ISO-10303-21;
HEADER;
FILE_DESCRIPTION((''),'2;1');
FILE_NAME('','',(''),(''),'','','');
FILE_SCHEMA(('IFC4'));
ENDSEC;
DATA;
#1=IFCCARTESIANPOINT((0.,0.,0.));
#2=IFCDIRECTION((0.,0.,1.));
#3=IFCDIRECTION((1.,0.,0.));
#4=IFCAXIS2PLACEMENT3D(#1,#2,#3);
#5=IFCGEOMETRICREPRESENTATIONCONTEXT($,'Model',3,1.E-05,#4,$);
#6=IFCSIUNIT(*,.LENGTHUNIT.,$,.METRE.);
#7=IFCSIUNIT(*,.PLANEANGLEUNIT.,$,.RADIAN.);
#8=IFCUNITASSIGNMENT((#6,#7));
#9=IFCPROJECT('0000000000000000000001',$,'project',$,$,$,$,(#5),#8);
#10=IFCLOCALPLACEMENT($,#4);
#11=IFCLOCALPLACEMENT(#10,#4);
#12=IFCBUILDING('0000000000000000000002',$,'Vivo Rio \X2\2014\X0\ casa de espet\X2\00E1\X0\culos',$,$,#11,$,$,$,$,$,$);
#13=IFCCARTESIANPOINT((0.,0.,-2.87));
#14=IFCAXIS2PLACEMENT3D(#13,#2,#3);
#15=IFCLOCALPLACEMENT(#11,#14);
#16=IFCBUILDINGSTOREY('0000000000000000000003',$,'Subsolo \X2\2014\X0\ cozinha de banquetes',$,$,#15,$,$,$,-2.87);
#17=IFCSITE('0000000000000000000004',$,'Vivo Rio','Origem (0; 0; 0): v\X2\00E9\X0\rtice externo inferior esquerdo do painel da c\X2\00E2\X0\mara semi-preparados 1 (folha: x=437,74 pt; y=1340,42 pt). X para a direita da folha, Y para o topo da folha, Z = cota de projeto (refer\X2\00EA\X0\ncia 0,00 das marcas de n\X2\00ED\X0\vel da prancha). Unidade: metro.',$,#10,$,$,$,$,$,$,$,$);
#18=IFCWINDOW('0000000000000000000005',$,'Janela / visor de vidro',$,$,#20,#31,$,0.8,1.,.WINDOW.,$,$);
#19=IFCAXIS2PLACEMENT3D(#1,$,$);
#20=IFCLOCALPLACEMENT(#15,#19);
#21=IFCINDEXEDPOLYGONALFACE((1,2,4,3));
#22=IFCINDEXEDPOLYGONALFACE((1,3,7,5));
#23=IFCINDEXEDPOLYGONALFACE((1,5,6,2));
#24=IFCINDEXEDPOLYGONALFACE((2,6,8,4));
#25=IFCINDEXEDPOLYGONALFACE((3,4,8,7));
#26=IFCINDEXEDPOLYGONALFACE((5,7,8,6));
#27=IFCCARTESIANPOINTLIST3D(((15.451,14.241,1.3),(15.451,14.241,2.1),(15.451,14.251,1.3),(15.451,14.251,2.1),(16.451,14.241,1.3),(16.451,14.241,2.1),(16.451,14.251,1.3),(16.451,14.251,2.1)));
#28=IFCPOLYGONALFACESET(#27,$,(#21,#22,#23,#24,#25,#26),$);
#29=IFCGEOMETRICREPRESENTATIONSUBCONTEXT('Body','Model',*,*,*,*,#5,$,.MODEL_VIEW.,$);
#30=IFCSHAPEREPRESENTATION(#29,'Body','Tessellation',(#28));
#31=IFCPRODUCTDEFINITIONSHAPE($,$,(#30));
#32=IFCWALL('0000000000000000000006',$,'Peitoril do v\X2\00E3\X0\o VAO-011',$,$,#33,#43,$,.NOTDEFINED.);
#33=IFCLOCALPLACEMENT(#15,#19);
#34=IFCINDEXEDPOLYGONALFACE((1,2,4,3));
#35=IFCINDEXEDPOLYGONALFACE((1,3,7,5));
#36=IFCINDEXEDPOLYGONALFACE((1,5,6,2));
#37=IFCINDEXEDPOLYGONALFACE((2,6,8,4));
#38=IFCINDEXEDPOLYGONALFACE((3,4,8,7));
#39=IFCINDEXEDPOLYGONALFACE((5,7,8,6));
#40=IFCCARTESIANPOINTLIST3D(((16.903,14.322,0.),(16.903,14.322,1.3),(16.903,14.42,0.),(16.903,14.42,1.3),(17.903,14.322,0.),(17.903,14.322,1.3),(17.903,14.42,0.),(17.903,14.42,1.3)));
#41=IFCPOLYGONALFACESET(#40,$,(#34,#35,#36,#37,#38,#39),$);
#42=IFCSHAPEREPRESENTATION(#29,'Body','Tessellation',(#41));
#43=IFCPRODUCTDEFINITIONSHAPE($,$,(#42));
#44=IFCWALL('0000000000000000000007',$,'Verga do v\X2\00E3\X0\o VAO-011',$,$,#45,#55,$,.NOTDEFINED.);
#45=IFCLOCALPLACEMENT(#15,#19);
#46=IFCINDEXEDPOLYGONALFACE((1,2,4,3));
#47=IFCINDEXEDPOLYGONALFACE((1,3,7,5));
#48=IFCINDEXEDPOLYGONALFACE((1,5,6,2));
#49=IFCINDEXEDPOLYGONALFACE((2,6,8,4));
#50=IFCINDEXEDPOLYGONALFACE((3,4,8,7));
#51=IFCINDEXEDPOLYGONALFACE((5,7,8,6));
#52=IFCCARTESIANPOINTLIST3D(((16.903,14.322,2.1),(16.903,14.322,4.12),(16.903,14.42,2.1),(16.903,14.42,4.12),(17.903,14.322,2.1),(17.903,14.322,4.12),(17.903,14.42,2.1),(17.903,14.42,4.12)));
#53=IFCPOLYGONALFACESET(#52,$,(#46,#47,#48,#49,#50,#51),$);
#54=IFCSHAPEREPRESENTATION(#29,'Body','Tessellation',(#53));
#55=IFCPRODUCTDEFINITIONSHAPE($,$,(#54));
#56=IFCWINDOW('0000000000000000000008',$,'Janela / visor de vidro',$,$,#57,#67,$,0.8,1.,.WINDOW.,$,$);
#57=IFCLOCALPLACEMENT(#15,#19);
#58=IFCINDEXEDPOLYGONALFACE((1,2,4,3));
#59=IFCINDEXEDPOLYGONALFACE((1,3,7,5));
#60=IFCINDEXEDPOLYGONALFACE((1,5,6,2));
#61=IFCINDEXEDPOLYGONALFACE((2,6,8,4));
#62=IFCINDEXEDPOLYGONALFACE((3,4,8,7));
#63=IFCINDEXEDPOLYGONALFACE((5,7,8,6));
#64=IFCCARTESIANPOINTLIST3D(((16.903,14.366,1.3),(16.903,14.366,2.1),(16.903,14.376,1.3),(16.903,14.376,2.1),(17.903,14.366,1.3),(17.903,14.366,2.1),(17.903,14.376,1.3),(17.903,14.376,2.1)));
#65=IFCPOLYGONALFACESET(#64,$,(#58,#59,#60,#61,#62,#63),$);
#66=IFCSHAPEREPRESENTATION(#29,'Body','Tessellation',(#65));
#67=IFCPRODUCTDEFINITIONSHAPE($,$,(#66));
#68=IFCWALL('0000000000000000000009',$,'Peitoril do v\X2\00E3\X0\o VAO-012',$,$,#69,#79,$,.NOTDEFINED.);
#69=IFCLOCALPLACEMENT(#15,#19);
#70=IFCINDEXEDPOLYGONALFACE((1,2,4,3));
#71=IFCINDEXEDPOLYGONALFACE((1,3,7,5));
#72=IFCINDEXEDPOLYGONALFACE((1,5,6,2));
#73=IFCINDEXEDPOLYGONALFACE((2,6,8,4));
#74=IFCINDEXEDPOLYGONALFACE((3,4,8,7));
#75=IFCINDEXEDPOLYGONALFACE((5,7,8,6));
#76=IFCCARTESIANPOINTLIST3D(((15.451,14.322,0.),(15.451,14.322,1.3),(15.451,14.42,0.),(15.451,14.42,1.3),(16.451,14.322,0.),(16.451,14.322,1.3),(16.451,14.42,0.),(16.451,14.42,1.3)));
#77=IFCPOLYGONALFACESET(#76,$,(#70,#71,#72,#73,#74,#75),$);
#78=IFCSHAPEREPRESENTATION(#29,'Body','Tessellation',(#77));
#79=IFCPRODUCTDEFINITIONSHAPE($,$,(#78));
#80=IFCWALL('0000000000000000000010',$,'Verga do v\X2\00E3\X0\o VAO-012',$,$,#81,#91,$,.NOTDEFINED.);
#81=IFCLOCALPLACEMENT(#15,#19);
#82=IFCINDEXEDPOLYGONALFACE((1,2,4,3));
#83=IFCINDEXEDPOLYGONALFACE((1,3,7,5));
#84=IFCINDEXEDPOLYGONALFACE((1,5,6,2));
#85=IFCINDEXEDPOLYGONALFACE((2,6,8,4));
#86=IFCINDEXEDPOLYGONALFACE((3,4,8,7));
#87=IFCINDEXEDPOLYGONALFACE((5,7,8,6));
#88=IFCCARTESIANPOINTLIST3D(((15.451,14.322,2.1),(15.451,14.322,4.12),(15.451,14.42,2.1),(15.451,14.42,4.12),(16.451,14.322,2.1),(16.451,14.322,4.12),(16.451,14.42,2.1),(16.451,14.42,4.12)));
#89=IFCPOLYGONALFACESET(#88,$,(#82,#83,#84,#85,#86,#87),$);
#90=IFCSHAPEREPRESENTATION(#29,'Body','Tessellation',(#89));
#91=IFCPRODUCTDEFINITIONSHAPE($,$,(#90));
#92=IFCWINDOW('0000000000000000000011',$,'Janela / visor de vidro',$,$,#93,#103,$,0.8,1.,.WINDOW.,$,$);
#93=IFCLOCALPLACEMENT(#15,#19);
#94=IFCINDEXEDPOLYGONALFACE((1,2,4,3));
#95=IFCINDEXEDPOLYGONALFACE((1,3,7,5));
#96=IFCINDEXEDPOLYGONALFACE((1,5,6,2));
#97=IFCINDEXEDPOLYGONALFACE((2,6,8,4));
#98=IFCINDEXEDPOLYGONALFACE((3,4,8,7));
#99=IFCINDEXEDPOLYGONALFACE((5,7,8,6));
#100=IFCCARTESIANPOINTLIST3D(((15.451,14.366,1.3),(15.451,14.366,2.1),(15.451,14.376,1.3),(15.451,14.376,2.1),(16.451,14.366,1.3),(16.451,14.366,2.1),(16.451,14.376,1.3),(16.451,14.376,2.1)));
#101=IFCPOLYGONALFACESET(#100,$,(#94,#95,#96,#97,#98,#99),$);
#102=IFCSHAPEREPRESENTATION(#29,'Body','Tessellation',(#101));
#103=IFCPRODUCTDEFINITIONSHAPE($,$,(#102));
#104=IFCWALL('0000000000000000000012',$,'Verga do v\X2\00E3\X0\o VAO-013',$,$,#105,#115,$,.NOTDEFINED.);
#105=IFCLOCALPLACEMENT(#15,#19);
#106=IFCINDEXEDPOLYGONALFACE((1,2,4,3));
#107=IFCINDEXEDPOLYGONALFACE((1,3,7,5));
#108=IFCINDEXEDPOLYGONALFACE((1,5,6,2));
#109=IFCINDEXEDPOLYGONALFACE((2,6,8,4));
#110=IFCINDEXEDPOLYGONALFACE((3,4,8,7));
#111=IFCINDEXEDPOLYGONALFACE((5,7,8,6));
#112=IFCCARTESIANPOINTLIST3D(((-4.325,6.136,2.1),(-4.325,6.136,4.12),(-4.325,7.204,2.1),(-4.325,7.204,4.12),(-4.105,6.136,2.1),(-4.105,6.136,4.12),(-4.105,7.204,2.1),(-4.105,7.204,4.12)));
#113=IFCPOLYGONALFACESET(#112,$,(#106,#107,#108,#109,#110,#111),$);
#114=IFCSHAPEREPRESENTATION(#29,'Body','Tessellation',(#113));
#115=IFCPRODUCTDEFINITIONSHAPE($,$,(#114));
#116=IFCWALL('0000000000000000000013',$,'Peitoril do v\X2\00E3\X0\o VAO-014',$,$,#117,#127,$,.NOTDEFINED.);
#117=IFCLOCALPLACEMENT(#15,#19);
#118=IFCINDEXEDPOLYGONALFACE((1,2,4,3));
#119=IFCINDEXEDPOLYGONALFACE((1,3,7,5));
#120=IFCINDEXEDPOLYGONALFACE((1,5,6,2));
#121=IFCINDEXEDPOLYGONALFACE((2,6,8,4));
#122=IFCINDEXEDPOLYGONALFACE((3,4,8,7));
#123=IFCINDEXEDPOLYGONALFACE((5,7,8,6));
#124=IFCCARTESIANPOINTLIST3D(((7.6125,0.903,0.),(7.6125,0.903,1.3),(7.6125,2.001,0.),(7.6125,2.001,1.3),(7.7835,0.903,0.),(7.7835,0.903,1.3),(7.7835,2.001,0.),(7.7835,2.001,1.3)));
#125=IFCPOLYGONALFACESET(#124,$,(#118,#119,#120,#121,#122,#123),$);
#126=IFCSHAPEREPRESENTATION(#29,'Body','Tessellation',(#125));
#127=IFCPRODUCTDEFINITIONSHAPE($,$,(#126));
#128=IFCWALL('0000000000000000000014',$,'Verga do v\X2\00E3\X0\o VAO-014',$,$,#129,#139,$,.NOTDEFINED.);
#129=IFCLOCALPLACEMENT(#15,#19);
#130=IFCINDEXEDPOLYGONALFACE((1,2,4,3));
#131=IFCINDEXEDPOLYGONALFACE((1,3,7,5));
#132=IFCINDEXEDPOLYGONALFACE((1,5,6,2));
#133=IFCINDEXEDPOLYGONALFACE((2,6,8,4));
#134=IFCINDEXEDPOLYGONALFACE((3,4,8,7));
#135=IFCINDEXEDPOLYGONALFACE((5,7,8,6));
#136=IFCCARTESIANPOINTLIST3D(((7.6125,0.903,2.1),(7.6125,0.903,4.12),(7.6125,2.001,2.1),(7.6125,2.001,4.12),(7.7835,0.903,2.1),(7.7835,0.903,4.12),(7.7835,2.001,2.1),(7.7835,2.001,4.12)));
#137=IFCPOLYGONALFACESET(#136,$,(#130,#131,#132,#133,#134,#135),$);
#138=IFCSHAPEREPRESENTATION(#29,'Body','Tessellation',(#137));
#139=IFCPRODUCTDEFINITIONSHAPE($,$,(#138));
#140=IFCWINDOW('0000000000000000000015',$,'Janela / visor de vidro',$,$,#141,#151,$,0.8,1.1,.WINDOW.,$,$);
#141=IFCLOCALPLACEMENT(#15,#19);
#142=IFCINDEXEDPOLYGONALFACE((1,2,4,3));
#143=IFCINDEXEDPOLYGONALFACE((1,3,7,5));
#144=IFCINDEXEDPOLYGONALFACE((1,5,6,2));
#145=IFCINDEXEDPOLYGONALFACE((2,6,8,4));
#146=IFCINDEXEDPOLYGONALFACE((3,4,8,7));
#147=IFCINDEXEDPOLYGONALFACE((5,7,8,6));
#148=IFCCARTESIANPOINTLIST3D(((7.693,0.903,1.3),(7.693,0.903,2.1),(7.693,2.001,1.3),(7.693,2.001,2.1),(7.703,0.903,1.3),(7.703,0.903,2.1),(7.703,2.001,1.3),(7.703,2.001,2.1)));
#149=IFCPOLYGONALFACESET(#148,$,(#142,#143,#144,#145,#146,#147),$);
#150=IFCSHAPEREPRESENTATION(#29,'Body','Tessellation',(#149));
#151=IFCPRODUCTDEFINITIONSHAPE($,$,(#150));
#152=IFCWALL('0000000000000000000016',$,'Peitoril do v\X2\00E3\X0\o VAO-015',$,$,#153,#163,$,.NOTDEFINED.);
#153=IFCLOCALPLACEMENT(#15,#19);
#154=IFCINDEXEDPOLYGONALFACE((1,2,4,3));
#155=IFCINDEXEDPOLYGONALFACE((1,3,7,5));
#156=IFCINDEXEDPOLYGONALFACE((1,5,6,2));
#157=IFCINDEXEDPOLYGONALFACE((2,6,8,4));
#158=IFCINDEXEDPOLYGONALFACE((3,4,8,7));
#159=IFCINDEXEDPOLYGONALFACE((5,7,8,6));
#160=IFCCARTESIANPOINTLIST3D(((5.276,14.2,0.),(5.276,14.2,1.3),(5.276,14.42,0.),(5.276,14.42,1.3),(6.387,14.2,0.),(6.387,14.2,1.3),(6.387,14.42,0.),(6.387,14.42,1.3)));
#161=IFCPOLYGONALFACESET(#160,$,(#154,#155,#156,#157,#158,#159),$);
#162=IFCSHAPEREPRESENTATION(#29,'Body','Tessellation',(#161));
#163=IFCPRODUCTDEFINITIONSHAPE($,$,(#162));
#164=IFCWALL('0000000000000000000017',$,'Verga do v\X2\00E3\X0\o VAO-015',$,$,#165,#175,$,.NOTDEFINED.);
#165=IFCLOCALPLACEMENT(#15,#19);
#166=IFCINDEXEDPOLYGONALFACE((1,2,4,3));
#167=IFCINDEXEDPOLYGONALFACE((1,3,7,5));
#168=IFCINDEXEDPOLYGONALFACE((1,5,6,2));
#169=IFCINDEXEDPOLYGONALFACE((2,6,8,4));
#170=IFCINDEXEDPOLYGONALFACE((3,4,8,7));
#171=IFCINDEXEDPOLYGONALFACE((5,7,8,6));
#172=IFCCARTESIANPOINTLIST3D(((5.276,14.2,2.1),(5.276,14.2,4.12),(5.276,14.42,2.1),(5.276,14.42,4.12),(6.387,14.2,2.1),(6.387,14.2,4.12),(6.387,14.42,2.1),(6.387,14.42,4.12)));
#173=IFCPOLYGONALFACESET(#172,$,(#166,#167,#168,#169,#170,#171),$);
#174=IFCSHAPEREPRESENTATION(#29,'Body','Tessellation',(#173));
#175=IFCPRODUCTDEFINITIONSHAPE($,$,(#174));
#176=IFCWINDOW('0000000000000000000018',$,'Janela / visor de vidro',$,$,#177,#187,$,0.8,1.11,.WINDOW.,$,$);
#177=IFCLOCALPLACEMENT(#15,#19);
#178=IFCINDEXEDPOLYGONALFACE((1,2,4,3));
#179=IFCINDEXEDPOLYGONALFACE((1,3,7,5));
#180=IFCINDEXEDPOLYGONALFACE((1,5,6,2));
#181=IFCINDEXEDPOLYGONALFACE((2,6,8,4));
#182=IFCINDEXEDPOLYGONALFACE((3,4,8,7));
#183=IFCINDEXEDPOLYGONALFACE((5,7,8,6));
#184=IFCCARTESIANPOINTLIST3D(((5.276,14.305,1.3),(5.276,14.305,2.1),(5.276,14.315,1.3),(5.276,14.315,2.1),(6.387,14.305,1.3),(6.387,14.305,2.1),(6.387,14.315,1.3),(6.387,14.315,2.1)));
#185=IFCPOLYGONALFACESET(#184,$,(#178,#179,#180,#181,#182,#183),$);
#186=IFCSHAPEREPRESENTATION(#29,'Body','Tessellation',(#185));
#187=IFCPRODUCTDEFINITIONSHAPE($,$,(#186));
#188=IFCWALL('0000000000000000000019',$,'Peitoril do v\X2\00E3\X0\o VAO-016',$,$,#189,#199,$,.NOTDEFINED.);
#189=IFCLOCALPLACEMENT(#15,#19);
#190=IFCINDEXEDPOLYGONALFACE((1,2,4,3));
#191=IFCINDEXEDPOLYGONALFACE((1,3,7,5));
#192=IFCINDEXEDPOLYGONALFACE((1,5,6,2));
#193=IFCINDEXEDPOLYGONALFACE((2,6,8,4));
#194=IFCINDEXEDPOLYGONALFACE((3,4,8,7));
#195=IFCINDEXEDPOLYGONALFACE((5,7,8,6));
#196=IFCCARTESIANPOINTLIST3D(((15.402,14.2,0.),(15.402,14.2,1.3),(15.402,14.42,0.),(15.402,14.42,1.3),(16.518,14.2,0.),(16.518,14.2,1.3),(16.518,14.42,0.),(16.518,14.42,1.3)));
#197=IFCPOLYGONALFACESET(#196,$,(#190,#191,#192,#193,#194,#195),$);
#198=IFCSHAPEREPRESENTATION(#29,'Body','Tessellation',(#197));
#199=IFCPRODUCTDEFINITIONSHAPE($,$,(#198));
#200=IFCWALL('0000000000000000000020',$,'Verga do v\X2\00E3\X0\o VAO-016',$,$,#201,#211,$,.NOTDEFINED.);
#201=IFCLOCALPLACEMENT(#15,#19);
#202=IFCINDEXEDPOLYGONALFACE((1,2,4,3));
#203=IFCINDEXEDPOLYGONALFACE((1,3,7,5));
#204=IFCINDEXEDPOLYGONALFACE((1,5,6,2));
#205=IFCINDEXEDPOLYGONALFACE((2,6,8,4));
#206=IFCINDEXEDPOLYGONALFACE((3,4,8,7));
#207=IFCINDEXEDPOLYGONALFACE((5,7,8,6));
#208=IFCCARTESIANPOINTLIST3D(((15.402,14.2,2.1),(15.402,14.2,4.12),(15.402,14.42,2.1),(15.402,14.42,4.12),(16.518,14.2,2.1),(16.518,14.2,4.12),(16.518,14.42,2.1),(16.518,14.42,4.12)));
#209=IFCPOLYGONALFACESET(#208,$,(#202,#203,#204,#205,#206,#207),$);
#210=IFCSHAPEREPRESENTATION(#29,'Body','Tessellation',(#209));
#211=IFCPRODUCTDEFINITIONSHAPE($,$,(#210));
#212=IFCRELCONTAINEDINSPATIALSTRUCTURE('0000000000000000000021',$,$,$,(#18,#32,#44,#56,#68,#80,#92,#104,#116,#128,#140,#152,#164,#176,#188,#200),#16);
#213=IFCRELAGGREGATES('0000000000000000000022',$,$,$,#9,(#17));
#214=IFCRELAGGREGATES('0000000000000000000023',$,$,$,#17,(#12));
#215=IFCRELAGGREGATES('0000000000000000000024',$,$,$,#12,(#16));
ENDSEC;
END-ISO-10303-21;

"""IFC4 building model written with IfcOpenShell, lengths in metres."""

from ifc_helpers import new_model, si_unit, frame, origin_with_axes, origin_2d, place, context, subcontext, project, spatial, rectangle, extrude, element, save


model = new_model("IFC4")

# Units and contexts
model_context = context("Model", 3, precision=1e-05, world=origin_with_axes())
body_context = subcontext(model_context, "Body", "Model", "MODEL_VIEW")
ifc_project = project(units=[si_unit("LENGTHUNIT", "METRE"), si_unit("PLANEANGLEUNIT", "RADIAN")], contexts=[model_context])

# Site, building, storey
site_placement = place(None, origin_with_axes())
site = spatial("IfcSite", under=ifc_project, at=site_placement, Name="Vivo Rio", Description="Origem (0; 0; 0): vértice externo inferior esquerdo do painel da câmara semi-preparados 1 (folha: x=437,74 pt; y=1340,42 pt). X para a direita da folha, Y para o topo da folha, Z = cota de projeto (referência 0,00 das marcas de nível da prancha). Unidade: metro.")
building_placement = place(site_placement, origin_with_axes())
building = spatial("IfcBuilding", under=site, at=building_placement, Name="Vivo Rio — casa de espetáculos")
storey_placement = place(building_placement, frame((0.0, 0.0, -2.87), z_axis=(0.0, 0.0, 1.0), x_axis=(1.0, 0.0, 0.0)))
storey = spatial("IfcBuildingStorey", under=building, at=storey_placement, Name="Subsolo — cozinha de banquetes", Elevation=-2.87)

# Window
window_1_placement = place(storey_placement, origin_with_axes())
element("IfcWindow", 1, at=window_1_placement, inside=storey, Name="Janela / visor de vidro", OverallHeight=0.8, OverallWidth=1.0, PredefinedType="WINDOW", context=body_context, shape_type="SweptSolid", body=[
    extrude(rectangle(XDim=1.0, YDim=0.01, at=origin_2d()), frame((15.951, 14.246, 1.3), z_axis=(0.0, 0.0, 1.0), x_axis=(1.0, 0.0, 0.0)), (0.0, 0.0, 1.0), 0.8),
])

# Walls
wall_1_placement = place(storey_placement, origin_with_axes())
element("IfcWall", 2, at=wall_1_placement, inside=storey, Name="Peitoril do vão VAO-011", PredefinedType="NOTDEFINED", context=body_context, shape_type="SweptSolid", body=[
    extrude(rectangle(XDim=1.0, YDim=0.098, at=origin_2d()), frame((17.403, 14.371, 0.0), z_axis=(0.0, 0.0, 1.0), x_axis=(1.0, 0.0, 0.0)), (0.0, 0.0, 1.0), 1.3),
])
wall_2_placement = place(storey_placement, origin_with_axes())
element("IfcWall", 3, at=wall_2_placement, inside=storey, Name="Verga do vão VAO-011", PredefinedType="NOTDEFINED", context=body_context, shape_type="SweptSolid", body=[
    extrude(rectangle(XDim=1.0, YDim=0.098, at=origin_2d()), frame((17.403, 14.371, 2.1), z_axis=(0.0, 0.0, 1.0), x_axis=(1.0, 0.0, 0.0)), (0.0, 0.0, 1.0), 2.02),
])

# Window
window_2_placement = place(storey_placement, origin_with_axes())
element("IfcWindow", 4, at=window_2_placement, inside=storey, Name="Janela / visor de vidro", OverallHeight=0.8, OverallWidth=1.0, PredefinedType="WINDOW", context=body_context, shape_type="SweptSolid", body=[
    extrude(rectangle(XDim=1.0, YDim=0.01, at=origin_2d()), frame((17.403, 14.371, 1.3), z_axis=(0.0, 0.0, 1.0), x_axis=(1.0, 0.0, 0.0)), (0.0, 0.0, 1.0), 0.8),
])

# Walls
wall_3_placement = place(storey_placement, origin_with_axes())
element("IfcWall", 5, at=wall_3_placement, inside=storey, Name="Peitoril do vão VAO-012", PredefinedType="NOTDEFINED", context=body_context, shape_type="SweptSolid", body=[
    extrude(rectangle(XDim=1.0, YDim=0.098, at=origin_2d()), frame((15.951, 14.371, 0.0), z_axis=(0.0, 0.0, 1.0), x_axis=(1.0, 0.0, 0.0)), (0.0, 0.0, 1.0), 1.3),
])
wall_4_placement = place(storey_placement, origin_with_axes())
element("IfcWall", 6, at=wall_4_placement, inside=storey, Name="Verga do vão VAO-012", PredefinedType="NOTDEFINED", context=body_context, shape_type="SweptSolid", body=[
    extrude(rectangle(XDim=1.0, YDim=0.098, at=origin_2d()), frame((15.951, 14.371, 2.1), z_axis=(0.0, 0.0, 1.0), x_axis=(1.0, 0.0, 0.0)), (0.0, 0.0, 1.0), 2.02),
])

# Window
window_3_placement = place(storey_placement, origin_with_axes())
element("IfcWindow", 7, at=window_3_placement, inside=storey, Name="Janela / visor de vidro", OverallHeight=0.8, OverallWidth=1.0, PredefinedType="WINDOW", context=body_context, shape_type="SweptSolid", body=[
    extrude(rectangle(XDim=1.0, YDim=0.01, at=origin_2d()), frame((15.951, 14.371, 1.3), z_axis=(0.0, 0.0, 1.0), x_axis=(1.0, 0.0, 0.0)), (0.0, 0.0, 1.0), 0.8),
])

# Walls
wall_5_placement = place(storey_placement, origin_with_axes())
element("IfcWall", 8, at=wall_5_placement, inside=storey, Name="Verga do vão VAO-013", PredefinedType="NOTDEFINED", context=body_context, shape_type="SweptSolid", body=[
    extrude(rectangle(XDim=1.068, YDim=0.22, at=origin_2d()), frame((-4.215, 6.67, 2.1), z_axis=(0.0, 0.0, 1.0), x_axis=(0.0, 1.0, 0.0)), (0.0, 0.0, 1.0), 2.02),
])
wall_6_placement = place(storey_placement, origin_with_axes())
element("IfcWall", 9, at=wall_6_placement, inside=storey, Name="Peitoril do vão VAO-014", PredefinedType="NOTDEFINED", context=body_context, shape_type="SweptSolid", body=[
    extrude(rectangle(XDim=1.098, YDim=0.171, at=origin_2d()), frame((7.698, 1.452, 0.0), z_axis=(0.0, 0.0, 1.0), x_axis=(0.0, 1.0, 0.0)), (0.0, 0.0, 1.0), 1.3),
])
wall_7_placement = place(storey_placement, origin_with_axes())
element("IfcWall", 10, at=wall_7_placement, inside=storey, Name="Verga do vão VAO-014", PredefinedType="NOTDEFINED", context=body_context, shape_type="SweptSolid", body=[
    extrude(rectangle(XDim=1.098, YDim=0.171, at=origin_2d()), frame((7.698, 1.452, 2.1), z_axis=(0.0, 0.0, 1.0), x_axis=(0.0, 1.0, 0.0)), (0.0, 0.0, 1.0), 2.02),
])

# Window
window_4_placement = place(storey_placement, origin_with_axes())
element("IfcWindow", 11, at=window_4_placement, inside=storey, Name="Janela / visor de vidro", OverallHeight=0.8, OverallWidth=1.1, PredefinedType="WINDOW", context=body_context, shape_type="SweptSolid", body=[
    extrude(rectangle(XDim=1.098, YDim=0.01, at=origin_2d()), frame((7.698, 1.452, 1.3), z_axis=(0.0, 0.0, 1.0), x_axis=(0.0, 1.0, 0.0)), (0.0, 0.0, 1.0), 0.8),
])

# Walls
wall_8_placement = place(storey_placement, origin_with_axes())
element("IfcWall", 12, at=wall_8_placement, inside=storey, Name="Peitoril do vão VAO-015", PredefinedType="NOTDEFINED", context=body_context, shape_type="SweptSolid", body=[
    extrude(rectangle(XDim=1.111, YDim=0.22, at=origin_2d()), frame((5.8315, 14.31, 0.0), z_axis=(0.0, 0.0, 1.0), x_axis=(1.0, 0.0, 0.0)), (0.0, 0.0, 1.0), 1.3),
])
wall_9_placement = place(storey_placement, origin_with_axes())
element("IfcWall", 13, at=wall_9_placement, inside=storey, Name="Verga do vão VAO-015", PredefinedType="NOTDEFINED", context=body_context, shape_type="SweptSolid", body=[
    extrude(rectangle(XDim=1.111, YDim=0.22, at=origin_2d()), frame((5.8315, 14.31, 2.1), z_axis=(0.0, 0.0, 1.0), x_axis=(1.0, 0.0, 0.0)), (0.0, 0.0, 1.0), 2.02),
])

# Window
window_5_placement = place(storey_placement, origin_with_axes())
element("IfcWindow", 14, at=window_5_placement, inside=storey, Name="Janela / visor de vidro", OverallHeight=0.8, OverallWidth=1.11, PredefinedType="WINDOW", context=body_context, shape_type="SweptSolid", body=[
    extrude(rectangle(XDim=1.111, YDim=0.01, at=origin_2d()), frame((5.8315, 14.31, 1.3), z_axis=(0.0, 0.0, 1.0), x_axis=(1.0, 0.0, 0.0)), (0.0, 0.0, 1.0), 0.8),
])

# Walls
wall_10_placement = place(storey_placement, origin_with_axes())
element("IfcWall", 15, at=wall_10_placement, inside=storey, Name="Peitoril do vão VAO-016", PredefinedType="NOTDEFINED", context=body_context, shape_type="SweptSolid", body=[
    extrude(rectangle(XDim=1.116, YDim=0.22, at=origin_2d()), frame((15.96, 14.31, 0.0), z_axis=(0.0, 0.0, 1.0), x_axis=(1.0, 0.0, 0.0)), (0.0, 0.0, 1.0), 1.3),
])
wall_11_placement = place(storey_placement, origin_with_axes())
element("IfcWall", 16, at=wall_11_placement, inside=storey, Name="Verga do vão VAO-016", PredefinedType="NOTDEFINED", context=body_context, shape_type="SweptSolid", body=[
    extrude(rectangle(XDim=1.116, YDim=0.22, at=origin_2d()), frame((15.96, 14.31, 2.1), z_axis=(0.0, 0.0, 1.0), x_axis=(1.0, 0.0, 0.0)), (0.0, 0.0, 1.0), 2.02),
])

save(model, "model.ifc")
